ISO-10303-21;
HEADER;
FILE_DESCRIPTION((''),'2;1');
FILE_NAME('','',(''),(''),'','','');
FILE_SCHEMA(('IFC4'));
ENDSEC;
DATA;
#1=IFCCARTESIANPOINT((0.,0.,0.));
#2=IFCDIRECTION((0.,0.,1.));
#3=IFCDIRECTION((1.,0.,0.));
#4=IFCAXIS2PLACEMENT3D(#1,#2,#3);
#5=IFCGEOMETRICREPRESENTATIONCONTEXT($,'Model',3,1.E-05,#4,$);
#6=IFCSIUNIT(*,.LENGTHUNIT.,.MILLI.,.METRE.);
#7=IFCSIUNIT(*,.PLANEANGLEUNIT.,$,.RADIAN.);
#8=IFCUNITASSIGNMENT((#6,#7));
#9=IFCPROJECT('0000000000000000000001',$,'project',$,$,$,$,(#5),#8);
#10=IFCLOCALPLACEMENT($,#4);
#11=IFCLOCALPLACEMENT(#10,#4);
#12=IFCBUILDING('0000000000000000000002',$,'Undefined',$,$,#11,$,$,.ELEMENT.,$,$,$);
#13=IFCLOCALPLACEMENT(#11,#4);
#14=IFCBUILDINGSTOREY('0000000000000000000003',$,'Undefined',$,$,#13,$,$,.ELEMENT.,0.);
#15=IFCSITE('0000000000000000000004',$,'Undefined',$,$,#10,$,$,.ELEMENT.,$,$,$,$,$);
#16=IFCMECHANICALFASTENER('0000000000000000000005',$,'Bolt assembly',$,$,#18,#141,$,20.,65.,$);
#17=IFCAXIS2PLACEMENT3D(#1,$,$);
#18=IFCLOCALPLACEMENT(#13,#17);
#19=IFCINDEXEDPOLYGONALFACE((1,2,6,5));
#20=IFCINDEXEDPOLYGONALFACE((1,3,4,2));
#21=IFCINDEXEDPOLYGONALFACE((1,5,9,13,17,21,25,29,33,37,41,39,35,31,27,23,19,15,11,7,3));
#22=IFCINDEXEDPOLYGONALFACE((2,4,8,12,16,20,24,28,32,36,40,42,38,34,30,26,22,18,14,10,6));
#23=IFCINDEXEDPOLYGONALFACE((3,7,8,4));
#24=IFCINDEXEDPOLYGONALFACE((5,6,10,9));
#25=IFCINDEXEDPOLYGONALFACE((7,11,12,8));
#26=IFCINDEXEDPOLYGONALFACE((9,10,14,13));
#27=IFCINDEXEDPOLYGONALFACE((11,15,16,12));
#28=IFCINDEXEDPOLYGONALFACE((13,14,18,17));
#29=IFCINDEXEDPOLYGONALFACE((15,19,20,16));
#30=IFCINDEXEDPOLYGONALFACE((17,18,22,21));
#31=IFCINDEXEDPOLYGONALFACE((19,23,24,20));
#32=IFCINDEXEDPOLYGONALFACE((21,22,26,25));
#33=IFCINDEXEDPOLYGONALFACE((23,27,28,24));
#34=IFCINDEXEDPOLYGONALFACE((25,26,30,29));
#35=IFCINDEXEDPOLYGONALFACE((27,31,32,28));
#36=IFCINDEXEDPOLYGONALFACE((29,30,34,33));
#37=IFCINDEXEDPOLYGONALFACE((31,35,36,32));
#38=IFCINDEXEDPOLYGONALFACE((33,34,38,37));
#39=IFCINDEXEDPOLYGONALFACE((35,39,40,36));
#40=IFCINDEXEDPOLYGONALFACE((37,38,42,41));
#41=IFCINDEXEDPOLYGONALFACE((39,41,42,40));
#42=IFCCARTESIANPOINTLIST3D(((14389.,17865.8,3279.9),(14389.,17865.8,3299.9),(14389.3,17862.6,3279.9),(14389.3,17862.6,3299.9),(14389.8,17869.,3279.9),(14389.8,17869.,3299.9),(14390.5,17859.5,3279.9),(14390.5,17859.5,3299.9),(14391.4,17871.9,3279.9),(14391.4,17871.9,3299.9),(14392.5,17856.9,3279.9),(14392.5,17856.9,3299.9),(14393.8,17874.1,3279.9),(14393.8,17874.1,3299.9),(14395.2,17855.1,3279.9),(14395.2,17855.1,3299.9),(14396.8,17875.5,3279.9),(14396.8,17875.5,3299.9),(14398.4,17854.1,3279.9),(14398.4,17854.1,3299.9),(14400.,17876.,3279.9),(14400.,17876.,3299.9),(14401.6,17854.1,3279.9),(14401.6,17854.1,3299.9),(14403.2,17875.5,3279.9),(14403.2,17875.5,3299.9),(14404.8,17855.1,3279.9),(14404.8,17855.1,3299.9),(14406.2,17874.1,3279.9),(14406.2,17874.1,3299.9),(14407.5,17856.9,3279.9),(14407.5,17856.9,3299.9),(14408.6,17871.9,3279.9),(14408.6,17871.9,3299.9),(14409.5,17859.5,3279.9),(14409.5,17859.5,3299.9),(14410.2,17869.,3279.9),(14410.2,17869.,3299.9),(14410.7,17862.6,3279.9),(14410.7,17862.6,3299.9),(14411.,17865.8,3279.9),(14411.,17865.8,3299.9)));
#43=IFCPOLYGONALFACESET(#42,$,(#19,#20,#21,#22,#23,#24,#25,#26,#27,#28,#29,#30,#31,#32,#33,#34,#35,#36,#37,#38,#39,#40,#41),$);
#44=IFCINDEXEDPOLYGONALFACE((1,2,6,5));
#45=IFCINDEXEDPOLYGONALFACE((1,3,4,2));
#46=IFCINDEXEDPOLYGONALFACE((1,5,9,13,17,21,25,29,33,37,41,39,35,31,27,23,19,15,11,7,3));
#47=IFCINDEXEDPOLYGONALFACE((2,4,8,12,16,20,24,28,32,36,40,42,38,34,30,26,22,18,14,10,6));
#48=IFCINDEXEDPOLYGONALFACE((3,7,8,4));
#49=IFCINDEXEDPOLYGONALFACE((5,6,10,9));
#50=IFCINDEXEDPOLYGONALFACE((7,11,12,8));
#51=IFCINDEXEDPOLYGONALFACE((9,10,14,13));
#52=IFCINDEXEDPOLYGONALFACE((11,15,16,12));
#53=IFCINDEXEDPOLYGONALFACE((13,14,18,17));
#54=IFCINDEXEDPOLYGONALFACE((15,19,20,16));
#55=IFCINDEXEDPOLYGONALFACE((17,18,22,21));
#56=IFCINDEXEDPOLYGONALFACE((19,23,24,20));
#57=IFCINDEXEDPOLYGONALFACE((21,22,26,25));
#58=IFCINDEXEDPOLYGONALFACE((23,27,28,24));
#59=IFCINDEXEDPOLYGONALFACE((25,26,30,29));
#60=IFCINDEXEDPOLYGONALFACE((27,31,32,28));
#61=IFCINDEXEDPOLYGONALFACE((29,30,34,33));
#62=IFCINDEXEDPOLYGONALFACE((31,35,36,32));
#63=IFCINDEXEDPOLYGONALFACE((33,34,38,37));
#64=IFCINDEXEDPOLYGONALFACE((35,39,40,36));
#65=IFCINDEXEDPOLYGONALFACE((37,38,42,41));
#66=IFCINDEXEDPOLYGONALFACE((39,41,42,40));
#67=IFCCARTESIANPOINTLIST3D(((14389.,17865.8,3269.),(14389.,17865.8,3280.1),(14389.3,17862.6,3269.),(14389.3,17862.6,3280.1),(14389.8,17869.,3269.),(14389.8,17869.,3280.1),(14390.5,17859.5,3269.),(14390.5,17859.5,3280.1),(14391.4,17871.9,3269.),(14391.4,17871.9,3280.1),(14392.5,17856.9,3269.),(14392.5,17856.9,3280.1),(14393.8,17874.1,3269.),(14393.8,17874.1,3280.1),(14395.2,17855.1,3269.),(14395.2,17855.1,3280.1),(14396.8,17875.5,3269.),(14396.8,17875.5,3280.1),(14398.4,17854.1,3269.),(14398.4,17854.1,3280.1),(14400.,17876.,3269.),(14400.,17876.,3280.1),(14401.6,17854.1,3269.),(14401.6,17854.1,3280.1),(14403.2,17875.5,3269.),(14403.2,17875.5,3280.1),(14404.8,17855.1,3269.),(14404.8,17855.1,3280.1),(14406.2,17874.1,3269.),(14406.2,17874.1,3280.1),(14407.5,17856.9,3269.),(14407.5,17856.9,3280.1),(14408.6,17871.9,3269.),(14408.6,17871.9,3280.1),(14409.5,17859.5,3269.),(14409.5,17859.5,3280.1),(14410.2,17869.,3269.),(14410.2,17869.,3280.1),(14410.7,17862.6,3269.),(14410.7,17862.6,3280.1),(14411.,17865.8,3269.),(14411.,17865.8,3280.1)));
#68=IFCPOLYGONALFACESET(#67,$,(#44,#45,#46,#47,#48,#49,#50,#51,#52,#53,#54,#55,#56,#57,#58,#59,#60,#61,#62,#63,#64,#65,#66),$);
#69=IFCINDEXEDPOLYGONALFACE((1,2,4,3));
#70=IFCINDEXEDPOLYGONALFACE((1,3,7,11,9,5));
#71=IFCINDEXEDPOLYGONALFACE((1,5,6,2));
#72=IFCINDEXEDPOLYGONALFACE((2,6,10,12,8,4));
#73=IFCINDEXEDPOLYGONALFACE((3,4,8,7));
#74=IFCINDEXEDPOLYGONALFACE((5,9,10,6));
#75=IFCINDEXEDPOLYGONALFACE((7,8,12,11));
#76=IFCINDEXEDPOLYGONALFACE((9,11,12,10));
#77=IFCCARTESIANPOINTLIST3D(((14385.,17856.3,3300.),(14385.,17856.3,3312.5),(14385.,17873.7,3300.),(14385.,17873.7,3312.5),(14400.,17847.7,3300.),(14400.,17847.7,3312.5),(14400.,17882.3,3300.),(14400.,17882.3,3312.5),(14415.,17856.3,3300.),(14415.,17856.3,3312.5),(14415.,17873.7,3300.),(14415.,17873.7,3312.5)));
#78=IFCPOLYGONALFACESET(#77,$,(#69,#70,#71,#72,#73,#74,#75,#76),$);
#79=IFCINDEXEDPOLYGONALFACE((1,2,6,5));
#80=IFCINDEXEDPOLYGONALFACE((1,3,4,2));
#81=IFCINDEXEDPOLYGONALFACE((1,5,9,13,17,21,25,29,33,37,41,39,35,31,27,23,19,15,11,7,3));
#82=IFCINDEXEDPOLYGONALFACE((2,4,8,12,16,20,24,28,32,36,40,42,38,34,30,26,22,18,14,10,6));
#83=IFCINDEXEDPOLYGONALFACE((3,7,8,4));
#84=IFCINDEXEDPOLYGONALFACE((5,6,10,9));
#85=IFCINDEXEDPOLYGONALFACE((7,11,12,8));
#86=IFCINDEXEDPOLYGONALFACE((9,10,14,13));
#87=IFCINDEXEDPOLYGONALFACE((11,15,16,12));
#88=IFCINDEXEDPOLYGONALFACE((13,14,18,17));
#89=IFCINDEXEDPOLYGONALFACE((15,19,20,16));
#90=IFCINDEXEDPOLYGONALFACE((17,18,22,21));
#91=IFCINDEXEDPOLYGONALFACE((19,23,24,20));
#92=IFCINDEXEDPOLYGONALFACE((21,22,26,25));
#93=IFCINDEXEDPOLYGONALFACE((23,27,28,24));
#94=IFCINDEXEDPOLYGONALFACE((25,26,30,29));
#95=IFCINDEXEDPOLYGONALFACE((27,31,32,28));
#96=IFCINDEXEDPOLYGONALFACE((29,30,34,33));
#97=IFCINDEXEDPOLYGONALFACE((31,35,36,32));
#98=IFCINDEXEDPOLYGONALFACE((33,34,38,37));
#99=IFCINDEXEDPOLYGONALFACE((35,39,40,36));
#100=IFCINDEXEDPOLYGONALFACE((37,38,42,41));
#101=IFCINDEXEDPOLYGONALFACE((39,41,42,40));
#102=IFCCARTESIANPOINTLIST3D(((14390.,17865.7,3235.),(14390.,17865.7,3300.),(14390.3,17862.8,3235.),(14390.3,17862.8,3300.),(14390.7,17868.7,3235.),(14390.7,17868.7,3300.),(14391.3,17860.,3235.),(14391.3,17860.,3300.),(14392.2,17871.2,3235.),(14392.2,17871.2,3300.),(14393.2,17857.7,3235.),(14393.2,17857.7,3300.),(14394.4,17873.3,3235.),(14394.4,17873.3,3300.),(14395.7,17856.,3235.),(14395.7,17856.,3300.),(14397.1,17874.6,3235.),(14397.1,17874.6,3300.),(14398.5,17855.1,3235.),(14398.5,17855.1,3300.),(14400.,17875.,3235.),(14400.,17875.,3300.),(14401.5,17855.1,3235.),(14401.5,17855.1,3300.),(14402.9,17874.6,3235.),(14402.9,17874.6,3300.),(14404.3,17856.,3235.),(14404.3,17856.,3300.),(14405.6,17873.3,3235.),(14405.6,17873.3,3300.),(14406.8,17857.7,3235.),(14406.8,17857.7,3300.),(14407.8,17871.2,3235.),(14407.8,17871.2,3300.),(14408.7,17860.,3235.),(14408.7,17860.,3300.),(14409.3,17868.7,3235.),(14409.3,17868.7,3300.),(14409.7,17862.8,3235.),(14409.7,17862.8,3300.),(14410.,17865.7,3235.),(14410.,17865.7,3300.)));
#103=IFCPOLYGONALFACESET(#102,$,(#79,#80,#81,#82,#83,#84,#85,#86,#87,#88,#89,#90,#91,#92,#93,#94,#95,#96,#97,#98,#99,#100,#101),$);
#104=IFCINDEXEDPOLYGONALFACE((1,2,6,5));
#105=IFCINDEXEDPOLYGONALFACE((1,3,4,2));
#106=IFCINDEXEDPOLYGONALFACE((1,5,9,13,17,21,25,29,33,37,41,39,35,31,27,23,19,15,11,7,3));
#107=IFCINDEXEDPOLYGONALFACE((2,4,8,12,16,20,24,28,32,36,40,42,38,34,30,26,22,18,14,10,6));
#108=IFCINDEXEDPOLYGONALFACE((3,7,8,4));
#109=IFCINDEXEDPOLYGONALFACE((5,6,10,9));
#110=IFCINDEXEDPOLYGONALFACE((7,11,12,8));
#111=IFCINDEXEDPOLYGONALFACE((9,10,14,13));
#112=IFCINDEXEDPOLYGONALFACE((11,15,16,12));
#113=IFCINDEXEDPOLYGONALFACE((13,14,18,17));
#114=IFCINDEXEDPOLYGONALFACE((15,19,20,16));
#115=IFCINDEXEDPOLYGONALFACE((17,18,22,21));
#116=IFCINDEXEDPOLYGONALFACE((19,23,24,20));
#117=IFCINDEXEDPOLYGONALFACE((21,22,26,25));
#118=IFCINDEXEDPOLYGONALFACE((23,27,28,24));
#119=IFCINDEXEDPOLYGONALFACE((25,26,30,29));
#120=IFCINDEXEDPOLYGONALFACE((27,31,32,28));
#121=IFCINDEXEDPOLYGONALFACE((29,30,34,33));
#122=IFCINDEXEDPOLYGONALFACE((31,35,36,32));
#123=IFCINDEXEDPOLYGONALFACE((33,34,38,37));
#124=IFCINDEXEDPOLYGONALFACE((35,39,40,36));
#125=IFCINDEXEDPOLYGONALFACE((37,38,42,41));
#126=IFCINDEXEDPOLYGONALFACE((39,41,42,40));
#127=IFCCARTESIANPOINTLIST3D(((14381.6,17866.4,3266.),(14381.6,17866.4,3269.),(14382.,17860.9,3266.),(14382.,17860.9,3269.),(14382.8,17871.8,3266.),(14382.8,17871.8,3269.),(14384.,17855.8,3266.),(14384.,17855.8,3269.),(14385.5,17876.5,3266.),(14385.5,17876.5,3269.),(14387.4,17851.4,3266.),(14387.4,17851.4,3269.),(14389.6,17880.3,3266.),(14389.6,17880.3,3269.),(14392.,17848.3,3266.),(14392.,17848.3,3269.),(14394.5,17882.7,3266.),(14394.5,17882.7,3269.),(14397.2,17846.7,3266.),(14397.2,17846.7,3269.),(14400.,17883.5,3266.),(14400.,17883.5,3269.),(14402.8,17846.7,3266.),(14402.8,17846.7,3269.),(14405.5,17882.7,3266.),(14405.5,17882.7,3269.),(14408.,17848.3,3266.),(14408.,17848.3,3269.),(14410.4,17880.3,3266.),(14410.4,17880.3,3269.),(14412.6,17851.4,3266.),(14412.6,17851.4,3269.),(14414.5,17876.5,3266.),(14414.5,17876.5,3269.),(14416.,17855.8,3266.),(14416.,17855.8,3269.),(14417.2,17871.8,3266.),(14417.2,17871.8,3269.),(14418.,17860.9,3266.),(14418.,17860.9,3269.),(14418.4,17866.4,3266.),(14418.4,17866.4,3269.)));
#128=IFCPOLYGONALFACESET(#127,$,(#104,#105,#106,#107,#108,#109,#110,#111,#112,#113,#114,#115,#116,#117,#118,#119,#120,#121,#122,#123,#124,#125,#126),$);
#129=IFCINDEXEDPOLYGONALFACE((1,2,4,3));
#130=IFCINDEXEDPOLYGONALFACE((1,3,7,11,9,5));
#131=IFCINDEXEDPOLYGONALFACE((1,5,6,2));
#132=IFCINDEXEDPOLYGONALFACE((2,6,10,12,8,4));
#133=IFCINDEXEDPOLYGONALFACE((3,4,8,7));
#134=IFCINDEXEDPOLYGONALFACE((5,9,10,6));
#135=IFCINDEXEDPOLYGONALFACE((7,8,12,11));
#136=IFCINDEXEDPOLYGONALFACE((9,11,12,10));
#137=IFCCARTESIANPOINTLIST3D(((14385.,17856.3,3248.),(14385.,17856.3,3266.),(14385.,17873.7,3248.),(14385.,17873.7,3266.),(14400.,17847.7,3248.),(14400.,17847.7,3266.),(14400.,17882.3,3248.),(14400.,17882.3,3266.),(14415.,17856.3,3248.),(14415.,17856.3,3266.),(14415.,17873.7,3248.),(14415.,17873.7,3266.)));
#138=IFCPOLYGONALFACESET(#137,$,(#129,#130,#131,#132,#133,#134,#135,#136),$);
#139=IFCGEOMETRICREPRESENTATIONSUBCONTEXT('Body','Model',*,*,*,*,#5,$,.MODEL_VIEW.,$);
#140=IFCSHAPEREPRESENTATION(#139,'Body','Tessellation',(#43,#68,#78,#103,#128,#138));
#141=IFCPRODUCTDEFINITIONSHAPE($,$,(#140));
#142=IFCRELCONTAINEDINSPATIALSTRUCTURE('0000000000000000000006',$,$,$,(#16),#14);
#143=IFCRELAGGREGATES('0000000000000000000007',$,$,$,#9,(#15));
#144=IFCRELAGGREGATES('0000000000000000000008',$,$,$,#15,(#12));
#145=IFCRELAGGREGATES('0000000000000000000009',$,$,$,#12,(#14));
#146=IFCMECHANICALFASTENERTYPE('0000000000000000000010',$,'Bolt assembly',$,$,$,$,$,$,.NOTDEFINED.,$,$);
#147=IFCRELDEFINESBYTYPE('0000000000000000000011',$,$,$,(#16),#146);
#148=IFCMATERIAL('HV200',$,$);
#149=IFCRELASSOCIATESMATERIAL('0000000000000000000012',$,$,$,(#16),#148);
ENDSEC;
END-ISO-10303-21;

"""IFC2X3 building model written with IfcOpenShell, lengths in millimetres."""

from ifc_helpers import new_model, si_unit, frame, origin_with_axes, origin_2d_with_axis, place, context, subcontext, project, spatial, polyline, circle, outline, extrude, source, transform, mapped, material, type_object, element, save


model = new_model("IFC2X3")

# Units and contexts
model_context = context("Model", 3, precision=1e-05, world=origin_with_axes())
body_context = subcontext(model_context, "Body", "Model", "MODEL_VIEW")
ifc_project = project(units=[si_unit("LENGTHUNIT", "METRE", prefix="MILLI"), si_unit("PLANEANGLEUNIT", "RADIAN")], contexts=[model_context])

# Site, building, storey
site_placement = place(None, origin_with_axes())
site = spatial("IfcSite", under=ifc_project, at=site_placement, Name="Undefined", CompositionType="ELEMENT")
building_placement = place(site_placement, origin_with_axes())
building = spatial("IfcBuilding", under=site, at=building_placement, Name="Undefined", CompositionType="ELEMENT")
storey_placement = place(building_placement, origin_with_axes())
storey = spatial("IfcBuildingStorey", under=building, at=storey_placement, Name="Undefined", CompositionType="ELEMENT", Elevation=0.0)

# Mechanical fastener
ifc_material_1 = material(Name="HV200")
mechanical_fastener_type = type_object("IfcMechanicalFastenerType", Name="Bolt assembly")
shared_shape_1 = source(origin_with_axes(), body_context, "Body", "SweptSolid", [
    extrude(circle(Radius=11.0, at=origin_2d_with_axis()), frame((0.0, -19.9, 0.0), z_axis=(0.0, 1.0, 0.0), x_axis=(1.0, 0.0, 0.0)), (0.0, 0.0, 1.0), 20.0),
    extrude(circle(Radius=11.0, at=origin_2d_with_axis()), frame((0.0, -0.1, 0.0), z_axis=(0.0, 1.0, 0.0), x_axis=(1.0, 0.0, 0.0)), (0.0, 0.0, 1.0), 11.1),
    extrude(outline(polyline([(17.3, 0.0), (8.7, 15.0), (-8.7, 15.0), (-17.3, 0.0), (-8.7, -15.0), (8.7, -15.0), (17.3, 0.0)])), frame((0.0, -32.5, 0.0), z_axis=(0.0, 1.0, 0.0), x_axis=(1.0, 0.0, 0.0)), (0.0, 0.0, 1.0), 12.5),
    extrude(circle(Radius=10.0, at=origin_2d_with_axis()), frame((0.0, -20.0, 0.0), z_axis=(0.0, 1.0, 0.0), x_axis=(1.0, 0.0, 0.0)), (0.0, 0.0, 1.0), 65.0),
    extrude(circle(Radius=18.5, at=origin_2d_with_axis()), frame((0.0, 11.0, 0.0), z_axis=(0.0, 1.0, 0.0), x_axis=(1.0, 0.0, 0.0)), (0.0, 0.0, 1.0), 3.0),
    extrude(outline(polyline([(17.3, 0.0), (8.7, 15.0), (-8.7, 15.0), (-17.3, 0.0), (-8.7, -15.0), (8.7, -15.0), (17.3, 0.0)])), frame((0.0, 14.0, 0.0), z_axis=(0.0, 1.0, 0.0), x_axis=(1.0, 0.0, 0.0)), (0.0, 0.0, 1.0), 18.0),
])
for number, where, z_axis, x_axis, name in (
    (1, (14400.0, 17865.0, 3280.0), (-1.0, 0.0, 0.0), (0.0, 1.0, 0.0), "Bolt assembly"),
):
    element("IfcMechanicalFastener", number, at=place(storey_placement, frame(where, z_axis=z_axis, x_axis=x_axis)), inside=storey, type_object=mechanical_fastener_type, material=ifc_material_1, Name=name, NominalDiameter=20.0, NominalLength=65.0, context=body_context, shape_type="MappedRepresentation", body=[
        mapped(shared_shape_1, transform((0.0, 0.0, 0.0))),
    ])

save(model, "model.ifc")
